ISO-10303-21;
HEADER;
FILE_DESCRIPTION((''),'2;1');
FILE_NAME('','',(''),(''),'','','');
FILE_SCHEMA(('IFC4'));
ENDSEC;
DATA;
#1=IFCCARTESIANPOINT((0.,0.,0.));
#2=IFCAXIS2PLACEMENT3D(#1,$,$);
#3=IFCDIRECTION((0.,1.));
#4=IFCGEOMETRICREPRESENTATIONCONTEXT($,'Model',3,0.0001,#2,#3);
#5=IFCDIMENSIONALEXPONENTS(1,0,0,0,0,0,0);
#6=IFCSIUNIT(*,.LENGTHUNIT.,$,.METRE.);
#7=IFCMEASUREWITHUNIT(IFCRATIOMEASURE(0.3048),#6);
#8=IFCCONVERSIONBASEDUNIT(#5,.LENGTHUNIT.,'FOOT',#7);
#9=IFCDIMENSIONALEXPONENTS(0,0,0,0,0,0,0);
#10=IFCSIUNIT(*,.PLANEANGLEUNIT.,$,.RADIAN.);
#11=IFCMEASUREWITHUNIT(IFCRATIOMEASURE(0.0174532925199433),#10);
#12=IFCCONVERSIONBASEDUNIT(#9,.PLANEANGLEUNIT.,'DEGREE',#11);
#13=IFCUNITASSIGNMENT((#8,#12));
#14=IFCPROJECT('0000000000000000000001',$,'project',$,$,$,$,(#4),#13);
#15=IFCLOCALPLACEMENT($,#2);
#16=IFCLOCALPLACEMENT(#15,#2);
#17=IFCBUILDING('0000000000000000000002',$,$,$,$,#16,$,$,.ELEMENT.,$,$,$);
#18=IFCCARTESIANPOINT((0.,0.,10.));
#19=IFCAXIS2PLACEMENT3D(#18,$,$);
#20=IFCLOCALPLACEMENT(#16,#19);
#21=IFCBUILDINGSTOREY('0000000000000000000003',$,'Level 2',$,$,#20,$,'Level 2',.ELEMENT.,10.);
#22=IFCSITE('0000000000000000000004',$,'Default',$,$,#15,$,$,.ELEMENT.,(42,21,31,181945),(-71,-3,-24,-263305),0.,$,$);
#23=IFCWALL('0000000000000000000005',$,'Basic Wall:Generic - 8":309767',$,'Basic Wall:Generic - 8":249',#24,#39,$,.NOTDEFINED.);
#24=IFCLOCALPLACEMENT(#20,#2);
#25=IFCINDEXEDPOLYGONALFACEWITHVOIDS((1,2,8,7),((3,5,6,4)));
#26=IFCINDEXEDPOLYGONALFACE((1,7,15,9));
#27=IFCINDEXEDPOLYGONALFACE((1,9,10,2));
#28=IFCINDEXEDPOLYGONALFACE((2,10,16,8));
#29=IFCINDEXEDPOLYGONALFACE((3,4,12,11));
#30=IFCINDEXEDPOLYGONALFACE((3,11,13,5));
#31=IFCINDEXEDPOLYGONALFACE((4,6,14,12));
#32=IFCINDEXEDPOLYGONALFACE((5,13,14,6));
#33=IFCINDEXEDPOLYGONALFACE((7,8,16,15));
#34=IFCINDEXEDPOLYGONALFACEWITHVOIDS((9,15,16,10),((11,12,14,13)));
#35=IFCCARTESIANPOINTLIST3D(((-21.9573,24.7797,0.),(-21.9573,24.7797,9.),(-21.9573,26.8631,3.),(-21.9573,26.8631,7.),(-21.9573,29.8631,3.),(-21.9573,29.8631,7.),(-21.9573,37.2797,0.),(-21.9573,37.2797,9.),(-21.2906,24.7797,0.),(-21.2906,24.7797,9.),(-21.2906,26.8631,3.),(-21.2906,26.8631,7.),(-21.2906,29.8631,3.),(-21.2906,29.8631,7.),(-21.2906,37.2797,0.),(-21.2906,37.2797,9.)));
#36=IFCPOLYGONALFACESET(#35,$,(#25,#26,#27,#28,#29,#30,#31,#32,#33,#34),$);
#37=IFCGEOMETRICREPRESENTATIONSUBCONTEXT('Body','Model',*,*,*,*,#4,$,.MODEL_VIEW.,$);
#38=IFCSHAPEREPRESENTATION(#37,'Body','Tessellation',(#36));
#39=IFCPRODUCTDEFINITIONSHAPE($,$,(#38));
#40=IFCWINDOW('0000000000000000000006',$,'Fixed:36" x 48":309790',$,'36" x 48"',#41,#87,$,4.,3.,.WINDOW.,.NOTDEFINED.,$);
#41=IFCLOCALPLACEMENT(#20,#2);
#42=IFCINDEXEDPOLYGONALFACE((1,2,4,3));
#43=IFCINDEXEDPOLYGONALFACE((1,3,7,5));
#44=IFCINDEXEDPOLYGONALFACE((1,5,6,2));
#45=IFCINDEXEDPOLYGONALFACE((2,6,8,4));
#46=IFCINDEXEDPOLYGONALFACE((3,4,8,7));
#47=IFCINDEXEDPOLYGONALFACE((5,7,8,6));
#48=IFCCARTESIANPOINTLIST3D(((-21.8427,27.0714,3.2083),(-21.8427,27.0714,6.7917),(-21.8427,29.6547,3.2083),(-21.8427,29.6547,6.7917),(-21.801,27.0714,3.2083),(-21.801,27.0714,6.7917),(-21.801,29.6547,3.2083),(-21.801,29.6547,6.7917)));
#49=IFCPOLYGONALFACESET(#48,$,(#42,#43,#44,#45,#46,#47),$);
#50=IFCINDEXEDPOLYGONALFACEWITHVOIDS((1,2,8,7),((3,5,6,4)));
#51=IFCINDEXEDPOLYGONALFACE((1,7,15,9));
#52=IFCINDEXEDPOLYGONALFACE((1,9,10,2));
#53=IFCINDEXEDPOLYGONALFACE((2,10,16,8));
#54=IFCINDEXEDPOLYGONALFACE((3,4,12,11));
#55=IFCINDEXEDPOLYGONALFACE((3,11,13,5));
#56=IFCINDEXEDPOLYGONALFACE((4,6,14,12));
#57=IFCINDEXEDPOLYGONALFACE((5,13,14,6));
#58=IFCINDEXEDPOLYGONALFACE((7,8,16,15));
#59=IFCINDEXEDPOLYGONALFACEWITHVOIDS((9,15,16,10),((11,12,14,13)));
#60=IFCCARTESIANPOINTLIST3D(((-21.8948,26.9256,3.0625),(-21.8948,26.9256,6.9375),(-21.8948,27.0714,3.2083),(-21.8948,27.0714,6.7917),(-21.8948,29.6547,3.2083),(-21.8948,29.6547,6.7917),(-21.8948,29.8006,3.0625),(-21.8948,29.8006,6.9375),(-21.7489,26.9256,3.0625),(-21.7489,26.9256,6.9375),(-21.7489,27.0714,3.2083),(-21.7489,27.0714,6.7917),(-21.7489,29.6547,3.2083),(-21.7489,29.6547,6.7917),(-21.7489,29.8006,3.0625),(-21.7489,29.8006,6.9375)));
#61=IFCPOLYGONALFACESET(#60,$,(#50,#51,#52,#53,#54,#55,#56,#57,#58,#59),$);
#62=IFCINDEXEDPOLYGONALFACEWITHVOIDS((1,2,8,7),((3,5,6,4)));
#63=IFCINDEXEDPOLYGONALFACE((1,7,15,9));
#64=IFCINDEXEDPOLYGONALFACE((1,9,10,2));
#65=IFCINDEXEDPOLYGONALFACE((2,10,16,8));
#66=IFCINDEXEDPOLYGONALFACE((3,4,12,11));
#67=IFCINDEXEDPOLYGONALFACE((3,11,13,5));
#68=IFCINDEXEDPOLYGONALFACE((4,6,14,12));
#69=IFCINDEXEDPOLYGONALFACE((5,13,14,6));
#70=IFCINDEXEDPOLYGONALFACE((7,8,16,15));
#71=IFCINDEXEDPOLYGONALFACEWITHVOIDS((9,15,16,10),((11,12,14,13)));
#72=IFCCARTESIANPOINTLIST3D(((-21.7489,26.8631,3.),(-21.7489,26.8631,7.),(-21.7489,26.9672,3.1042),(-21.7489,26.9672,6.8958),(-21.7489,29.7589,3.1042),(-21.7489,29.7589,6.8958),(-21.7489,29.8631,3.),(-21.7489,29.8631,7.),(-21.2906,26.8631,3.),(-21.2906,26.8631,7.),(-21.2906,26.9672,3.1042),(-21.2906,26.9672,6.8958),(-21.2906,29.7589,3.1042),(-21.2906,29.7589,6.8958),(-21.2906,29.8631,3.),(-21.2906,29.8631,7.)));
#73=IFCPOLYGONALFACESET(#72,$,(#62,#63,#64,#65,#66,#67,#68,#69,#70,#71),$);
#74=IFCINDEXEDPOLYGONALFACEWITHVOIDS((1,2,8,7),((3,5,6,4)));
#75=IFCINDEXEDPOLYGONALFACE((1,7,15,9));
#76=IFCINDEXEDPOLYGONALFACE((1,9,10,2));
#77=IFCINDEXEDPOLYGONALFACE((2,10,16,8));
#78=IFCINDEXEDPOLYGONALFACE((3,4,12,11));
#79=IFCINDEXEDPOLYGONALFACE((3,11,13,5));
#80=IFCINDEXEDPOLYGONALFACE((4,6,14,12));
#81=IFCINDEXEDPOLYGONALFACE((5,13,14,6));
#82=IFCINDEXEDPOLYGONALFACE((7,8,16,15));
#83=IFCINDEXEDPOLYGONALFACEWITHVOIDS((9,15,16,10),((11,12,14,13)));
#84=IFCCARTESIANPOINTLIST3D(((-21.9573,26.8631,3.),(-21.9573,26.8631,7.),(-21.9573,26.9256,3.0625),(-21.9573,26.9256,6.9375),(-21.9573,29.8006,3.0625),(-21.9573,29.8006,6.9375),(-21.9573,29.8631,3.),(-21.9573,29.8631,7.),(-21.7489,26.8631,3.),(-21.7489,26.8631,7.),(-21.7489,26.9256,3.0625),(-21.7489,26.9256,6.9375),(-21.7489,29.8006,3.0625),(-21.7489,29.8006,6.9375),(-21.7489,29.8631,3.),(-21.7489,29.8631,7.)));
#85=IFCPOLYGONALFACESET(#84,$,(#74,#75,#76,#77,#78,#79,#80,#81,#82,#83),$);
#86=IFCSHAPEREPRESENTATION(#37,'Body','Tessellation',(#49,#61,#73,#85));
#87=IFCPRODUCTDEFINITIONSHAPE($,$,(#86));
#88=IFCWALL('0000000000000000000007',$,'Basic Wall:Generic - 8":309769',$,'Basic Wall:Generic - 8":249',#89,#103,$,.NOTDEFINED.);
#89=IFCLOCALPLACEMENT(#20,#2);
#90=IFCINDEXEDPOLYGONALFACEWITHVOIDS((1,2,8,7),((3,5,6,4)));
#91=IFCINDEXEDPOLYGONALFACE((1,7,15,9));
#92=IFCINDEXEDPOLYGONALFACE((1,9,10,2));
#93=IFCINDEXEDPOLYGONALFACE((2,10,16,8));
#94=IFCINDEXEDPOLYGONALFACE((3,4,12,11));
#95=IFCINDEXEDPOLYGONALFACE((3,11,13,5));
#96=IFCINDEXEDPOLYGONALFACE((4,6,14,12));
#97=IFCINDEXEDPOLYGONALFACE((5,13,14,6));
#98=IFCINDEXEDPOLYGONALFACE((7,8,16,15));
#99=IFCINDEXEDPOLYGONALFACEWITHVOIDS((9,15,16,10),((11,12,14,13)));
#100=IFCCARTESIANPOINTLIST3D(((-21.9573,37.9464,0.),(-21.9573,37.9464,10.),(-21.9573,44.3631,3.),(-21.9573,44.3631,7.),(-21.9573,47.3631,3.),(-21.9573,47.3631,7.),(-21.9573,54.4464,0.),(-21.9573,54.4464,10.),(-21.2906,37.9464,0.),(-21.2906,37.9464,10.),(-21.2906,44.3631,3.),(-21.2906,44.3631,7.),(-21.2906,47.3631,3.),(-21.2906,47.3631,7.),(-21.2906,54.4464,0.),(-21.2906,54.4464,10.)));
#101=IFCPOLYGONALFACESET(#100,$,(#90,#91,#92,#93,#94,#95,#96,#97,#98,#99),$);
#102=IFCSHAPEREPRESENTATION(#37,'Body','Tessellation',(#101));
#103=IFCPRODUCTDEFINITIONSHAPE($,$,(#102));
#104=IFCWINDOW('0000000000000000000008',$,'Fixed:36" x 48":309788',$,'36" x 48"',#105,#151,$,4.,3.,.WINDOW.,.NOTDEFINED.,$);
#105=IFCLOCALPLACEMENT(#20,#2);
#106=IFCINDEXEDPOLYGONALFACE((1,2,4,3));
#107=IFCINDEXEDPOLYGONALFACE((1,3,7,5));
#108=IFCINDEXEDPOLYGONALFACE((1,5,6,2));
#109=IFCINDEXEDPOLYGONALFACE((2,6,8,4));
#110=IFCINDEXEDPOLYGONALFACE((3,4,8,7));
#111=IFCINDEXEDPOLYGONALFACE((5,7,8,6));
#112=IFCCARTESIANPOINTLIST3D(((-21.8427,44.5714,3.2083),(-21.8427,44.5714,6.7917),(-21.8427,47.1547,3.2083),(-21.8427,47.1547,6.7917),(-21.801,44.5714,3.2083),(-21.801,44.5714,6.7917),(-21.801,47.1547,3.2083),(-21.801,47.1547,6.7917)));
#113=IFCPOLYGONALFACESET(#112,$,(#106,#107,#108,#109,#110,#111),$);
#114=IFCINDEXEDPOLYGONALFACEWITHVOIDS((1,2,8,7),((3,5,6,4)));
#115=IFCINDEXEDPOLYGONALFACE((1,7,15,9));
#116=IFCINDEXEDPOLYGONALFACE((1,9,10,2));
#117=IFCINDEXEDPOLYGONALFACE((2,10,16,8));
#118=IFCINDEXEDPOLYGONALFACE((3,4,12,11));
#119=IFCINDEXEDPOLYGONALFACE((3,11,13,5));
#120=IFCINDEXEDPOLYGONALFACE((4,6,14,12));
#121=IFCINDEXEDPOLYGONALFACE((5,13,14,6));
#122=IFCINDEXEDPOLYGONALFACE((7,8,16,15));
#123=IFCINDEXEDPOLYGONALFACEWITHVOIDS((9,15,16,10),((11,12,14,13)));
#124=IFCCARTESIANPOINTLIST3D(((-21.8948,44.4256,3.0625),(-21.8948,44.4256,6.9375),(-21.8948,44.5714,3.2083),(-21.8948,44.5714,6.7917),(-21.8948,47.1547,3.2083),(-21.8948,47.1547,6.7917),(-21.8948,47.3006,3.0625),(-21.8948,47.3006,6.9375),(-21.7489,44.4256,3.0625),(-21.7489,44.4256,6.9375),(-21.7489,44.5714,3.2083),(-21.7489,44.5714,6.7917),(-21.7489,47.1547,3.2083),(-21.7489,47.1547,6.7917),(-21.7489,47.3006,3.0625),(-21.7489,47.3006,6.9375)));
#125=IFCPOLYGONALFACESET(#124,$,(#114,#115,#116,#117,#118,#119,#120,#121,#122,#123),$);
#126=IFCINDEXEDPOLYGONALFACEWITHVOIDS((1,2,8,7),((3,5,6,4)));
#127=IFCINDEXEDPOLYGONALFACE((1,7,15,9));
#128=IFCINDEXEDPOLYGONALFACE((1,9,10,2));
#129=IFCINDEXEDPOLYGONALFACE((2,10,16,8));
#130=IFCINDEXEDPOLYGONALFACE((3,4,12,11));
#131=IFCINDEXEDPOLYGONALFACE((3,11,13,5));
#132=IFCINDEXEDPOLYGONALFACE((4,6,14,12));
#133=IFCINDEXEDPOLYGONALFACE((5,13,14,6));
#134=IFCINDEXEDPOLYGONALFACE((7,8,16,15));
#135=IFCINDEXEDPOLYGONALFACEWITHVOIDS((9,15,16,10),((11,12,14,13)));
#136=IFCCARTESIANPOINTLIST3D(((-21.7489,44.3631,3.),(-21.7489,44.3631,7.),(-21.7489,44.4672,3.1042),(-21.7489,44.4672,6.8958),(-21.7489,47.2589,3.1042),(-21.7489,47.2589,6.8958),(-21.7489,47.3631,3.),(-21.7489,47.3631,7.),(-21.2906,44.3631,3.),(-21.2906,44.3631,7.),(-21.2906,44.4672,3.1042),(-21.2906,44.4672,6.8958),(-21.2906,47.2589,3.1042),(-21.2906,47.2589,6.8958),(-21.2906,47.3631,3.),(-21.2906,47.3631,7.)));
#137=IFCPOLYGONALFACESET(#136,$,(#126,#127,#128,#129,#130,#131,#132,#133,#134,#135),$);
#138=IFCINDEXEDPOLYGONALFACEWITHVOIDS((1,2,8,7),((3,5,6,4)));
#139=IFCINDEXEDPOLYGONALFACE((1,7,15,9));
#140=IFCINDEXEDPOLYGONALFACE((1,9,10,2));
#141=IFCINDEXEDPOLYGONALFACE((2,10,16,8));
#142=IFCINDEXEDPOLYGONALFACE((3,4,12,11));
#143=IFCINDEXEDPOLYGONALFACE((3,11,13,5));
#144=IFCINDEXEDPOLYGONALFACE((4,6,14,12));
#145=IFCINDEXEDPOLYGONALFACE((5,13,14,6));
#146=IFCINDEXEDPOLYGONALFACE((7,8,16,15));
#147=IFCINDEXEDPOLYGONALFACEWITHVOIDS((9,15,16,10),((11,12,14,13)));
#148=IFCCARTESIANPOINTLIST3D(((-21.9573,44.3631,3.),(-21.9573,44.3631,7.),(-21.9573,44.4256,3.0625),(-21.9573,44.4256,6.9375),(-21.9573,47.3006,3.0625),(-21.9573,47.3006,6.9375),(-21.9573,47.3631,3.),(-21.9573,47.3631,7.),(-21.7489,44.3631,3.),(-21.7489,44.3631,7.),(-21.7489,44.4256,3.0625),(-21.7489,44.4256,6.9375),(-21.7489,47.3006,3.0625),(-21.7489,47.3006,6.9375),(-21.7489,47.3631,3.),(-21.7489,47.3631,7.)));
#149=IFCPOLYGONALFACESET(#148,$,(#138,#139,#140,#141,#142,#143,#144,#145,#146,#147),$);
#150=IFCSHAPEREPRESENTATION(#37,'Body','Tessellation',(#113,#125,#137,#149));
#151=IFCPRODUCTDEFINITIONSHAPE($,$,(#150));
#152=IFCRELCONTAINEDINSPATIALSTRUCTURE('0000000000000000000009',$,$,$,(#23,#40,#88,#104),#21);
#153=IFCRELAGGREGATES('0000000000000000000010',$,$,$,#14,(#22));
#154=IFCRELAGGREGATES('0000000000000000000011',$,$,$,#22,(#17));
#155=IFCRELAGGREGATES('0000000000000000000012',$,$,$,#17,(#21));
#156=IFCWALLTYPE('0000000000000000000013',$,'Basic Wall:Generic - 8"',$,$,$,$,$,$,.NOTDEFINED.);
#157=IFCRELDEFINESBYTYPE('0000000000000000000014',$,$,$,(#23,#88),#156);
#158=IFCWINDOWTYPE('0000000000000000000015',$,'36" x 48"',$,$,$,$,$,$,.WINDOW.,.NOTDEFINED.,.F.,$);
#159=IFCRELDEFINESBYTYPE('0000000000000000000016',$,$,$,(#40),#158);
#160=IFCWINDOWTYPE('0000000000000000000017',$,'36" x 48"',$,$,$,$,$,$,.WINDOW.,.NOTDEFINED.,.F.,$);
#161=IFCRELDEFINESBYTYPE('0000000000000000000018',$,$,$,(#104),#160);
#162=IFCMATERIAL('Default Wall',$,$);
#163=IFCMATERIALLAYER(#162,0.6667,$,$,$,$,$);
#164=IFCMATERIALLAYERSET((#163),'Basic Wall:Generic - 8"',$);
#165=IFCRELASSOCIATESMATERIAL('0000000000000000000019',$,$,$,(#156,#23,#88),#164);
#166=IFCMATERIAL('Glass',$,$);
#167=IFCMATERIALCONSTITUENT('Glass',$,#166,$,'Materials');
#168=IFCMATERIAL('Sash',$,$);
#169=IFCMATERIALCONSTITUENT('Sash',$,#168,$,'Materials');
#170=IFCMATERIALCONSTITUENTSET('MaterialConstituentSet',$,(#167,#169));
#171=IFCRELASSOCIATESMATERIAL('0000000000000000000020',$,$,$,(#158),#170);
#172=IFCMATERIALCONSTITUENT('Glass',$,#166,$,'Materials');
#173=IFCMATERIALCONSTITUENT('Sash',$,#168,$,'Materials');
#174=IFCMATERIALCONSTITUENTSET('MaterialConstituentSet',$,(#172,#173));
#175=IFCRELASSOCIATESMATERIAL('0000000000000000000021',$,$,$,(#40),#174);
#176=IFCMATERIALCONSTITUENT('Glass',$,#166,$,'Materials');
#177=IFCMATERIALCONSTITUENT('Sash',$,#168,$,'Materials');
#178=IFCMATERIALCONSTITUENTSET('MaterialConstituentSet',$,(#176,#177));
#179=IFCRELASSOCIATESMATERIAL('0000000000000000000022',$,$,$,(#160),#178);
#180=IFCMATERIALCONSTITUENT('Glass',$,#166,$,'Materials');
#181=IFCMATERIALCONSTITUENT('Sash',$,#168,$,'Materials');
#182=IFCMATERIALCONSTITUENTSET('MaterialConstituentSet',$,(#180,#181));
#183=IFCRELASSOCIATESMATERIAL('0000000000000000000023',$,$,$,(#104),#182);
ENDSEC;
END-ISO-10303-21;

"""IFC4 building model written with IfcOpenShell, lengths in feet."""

from ifc_helpers import new_model, entity, si_unit, converted_unit, direction, frame, frame_2d, origin, place, context, subcontext, project, spatial, polyline, rectangle, outline, extrude, clip, bounded_halfspace, source, transform, mapped, material, layer, layer_set, layer_usage, constituent, constituent_set, type_object, type_shapes, element, fill, save


model = new_model("IFC4")

# Units and contexts
model_context = context("Model", 3, precision=0.0001, world=origin(), true_north=direction((0.0, 1.0)))
body_context = subcontext(model_context, "Body", "Model", "MODEL_VIEW")
ifc_project = project(units=[converted_unit("LENGTHUNIT", "FOOT", entity("IfcRatioMeasure", 0.3048), si_unit("LENGTHUNIT", "METRE"), dimensions=[1, 0, 0, 0, 0, 0, 0]), converted_unit("PLANEANGLEUNIT", "DEGREE", entity("IfcRatioMeasure", 0.0174532925199433), si_unit("PLANEANGLEUNIT", "RADIAN"), dimensions=[0, 0, 0, 0, 0, 0, 0])], contexts=[model_context])

# Site, building, storey
site_placement = place(None, origin())
site = spatial("IfcSite", under=ifc_project, at=site_placement, Name="Default", CompositionType="ELEMENT", RefLatitude=(42, 21, 31, 181945), RefLongitude=(-71, -3, -24, -263305), RefElevation=0.0)
building_placement = place(site_placement, origin())
building = spatial("IfcBuilding", under=site, at=building_placement, CompositionType="ELEMENT")
storey_placement = place(building_placement, frame((0.0, 0.0, 10.0)))
storey = spatial("IfcBuildingStorey", under=building, at=storey_placement, Name="Level 2", LongName="Level 2", CompositionType="ELEMENT", Elevation=10.0)

# Shared definitions
ifc_material_1 = material(Name="Default Wall")
ifc_layer_1 = layer(ifc_material_1, 0.6667)
ifc_layer_set_1 = layer_set([ifc_layer_1], Name="Basic Wall:Generic - 8\"")
wall_type = type_object("IfcWallType", Name="Basic Wall:Generic - 8\"", PredefinedType="NOTDEFINED", material=ifc_layer_set_1)

# Walls, openings, windows
ifc_layer_usage_1 = layer_usage(ifc_layer_set_1, "AXIS2", "NEGATIVE", 0.3333)
wall_1_placement = place(storey_placement, frame((-21.6239, 24.7797, 0.0), z_axis=(0.0, 0.0, 1.0), x_axis=(0.0, 1.0, 0.0)))
wall_1 = element("IfcWall", 1, at=wall_1_placement, inside=storey, type_object=wall_type, material=ifc_layer_usage_1, Name="Basic Wall:Generic - 8\":309767", ObjectType="Basic Wall:Generic - 8\":249", PredefinedType="NOTDEFINED", context=body_context, shape_type="Clipping", body=[
    clip(extrude(rectangle(XDim=12.5, YDim=0.6667, at=frame_2d((6.25, 0.0), x_axis=(-1.0, 0.0))), origin(), (0.0, 0.0, 1.0), 9.0), bounded_halfspace(frame((0.0, -0.3333, 9.0), z_axis=(0.0, 0.0, -1.0), x_axis=(0.0, -1.0, 0.0)), True, frame((0.0, -0.3333, 9.0)), polyline([(0.0, 0.0), (12.5, 0.0), (12.5, 0.6667), (0.6667, 0.6667), (0.0, 0.6667), (0.0, 0.0)]))),
])
opening_1_placement = place(wall_1_placement, frame((2.0833, -0.3333, 3.0)))
opening_1 = element("IfcOpeningElement", 2, at=opening_1_placement, cuts=wall_1, ObjectType="Opening", PredefinedType="OPENING", context=body_context, shape_type="SweptSolid", body=[
    extrude(rectangle(XDim=4.0, YDim=3.0, at=frame_2d((2.0, 1.5), x_axis=(-1.0, 0.0))), frame((0.0, 0.0, 0.0), z_axis=(0.0, 1.0, 0.0), x_axis=(0.0, 0.0, 1.0)), (0.0, 0.0, 1.0), 0.6667),
])
ifc_material_2 = material(Name="Glass")
ifc_constituent_1 = constituent(ifc_material_2, Name="Glass", Category="Materials")
ifc_material_3 = material(Name="Sash")
ifc_constituent_2 = constituent(ifc_material_3, Name="Sash", Category="Materials")
ifc_constituent_set_1 = constituent_set(constituents=[ifc_constituent_1, ifc_constituent_2], Name="MaterialConstituentSet")
ifc_constituent_3 = constituent(ifc_material_2, Name="Glass", Category="Materials")
ifc_constituent_4 = constituent(ifc_material_3, Name="Sash", Category="Materials")
ifc_constituent_set_2 = constituent_set(constituents=[ifc_constituent_3, ifc_constituent_4], Name="MaterialConstituentSet")
window_type_1 = type_object("IfcWindowType", Name="36\" x 48\"", ParameterTakesPrecedence=False, PartitioningType="NOTDEFINED", PredefinedType="WINDOW", material=ifc_constituent_set_2)
shared_shape_1 = source(origin(), body_context, "Body", "SweptSolid", [
    extrude(rectangle(XDim=2.5833, YDim=0.0417, at=frame_2d((0.0, 0.0), x_axis=(1.0, 0.0))), frame((1.75, 0.5312, 0.2083)), (0.0, 0.0, 1.0), 3.5833),
    extrude(outline(polyline([(-1.4375, -1.9375), (1.4375, -1.9375), (1.4375, 1.9375), (-1.4375, 1.9375), (-1.4375, -1.9375)]), holes=[polyline([(-1.2917, -1.7917), (-1.2917, 1.7917), (1.2917, 1.7917), (1.2917, -1.7917), (-1.2917, -1.7917)])]), frame((1.75, 0.6042, 2.0), z_axis=(0.0, -1.0, 0.0), x_axis=(-1.0, 0.0, 0.0)), (0.0, 0.0, 1.0), 0.1458),
    extrude(outline(polyline([(-1.5, -2.0), (1.5, -2.0), (1.5, 2.0), (-1.5, 2.0), (-1.5, -2.0)]), holes=[polyline([(-1.3958, -1.8958), (-1.3958, 1.8958), (1.3958, 1.8958), (1.3958, -1.8958), (-1.3958, -1.8958)])]), frame((1.75, 0.4583, 2.0), z_axis=(0.0, -1.0, 0.0), x_axis=(-1.0, 0.0, 0.0)), (0.0, 0.0, 1.0), 0.4583),
    extrude(outline(polyline([(-2.0, -1.5), (2.0, -1.5), (2.0, 1.5), (-2.0, 1.5), (-2.0, -1.5)]), holes=[polyline([(-1.9375, -1.4375), (-1.9375, 1.4375), (1.9375, 1.4375), (1.9375, -1.4375), (-1.9375, -1.4375)])]), frame((1.75, 0.6667, 2.0), z_axis=(0.0, -1.0, 0.0), x_axis=(0.0, 0.0, -1.0)), (0.0, 0.0, 1.0), 0.2083),
])
type_shapes(window_type_1, [shared_shape_1])
window_1_placement = place(opening_1_placement, frame((-0.25, 0.0, 0.0)))
window_1 = element("IfcWindow", 3, at=window_1_placement, inside=storey, type_object=window_type_1, material=ifc_constituent_set_1, Name="Fixed:36\" x 48\":309790", ObjectType="36\" x 48\"", OverallHeight=4.0, OverallWidth=3.0, PartitioningType="NOTDEFINED", PredefinedType="WINDOW", context=body_context, shape_type="MappedRepresentation", body=[
    mapped(shared_shape_1, transform((0.0, 0.0, 0.0), scale=1.0)),
])
fill(opening_1, window_1)
ifc_layer_usage_2 = layer_usage(ifc_layer_set_1, "AXIS2", "NEGATIVE", 0.3333)
wall_2_placement = place(storey_placement, frame((-21.6239, 54.4464, 0.0), z_axis=(0.0, 0.0, 1.0), x_axis=(0.0, -1.0, 0.0)))
wall_2 = element("IfcWall", 4, at=wall_2_placement, inside=storey, type_object=wall_type, material=ifc_layer_usage_2, Name="Basic Wall:Generic - 8\":309769", ObjectType="Basic Wall:Generic - 8\":249", PredefinedType="NOTDEFINED", context=body_context, shape_type="SweptSolid", body=[
    extrude(rectangle(XDim=16.5, YDim=0.6667, at=frame_2d((8.25, 0.0), x_axis=(-1.0, 0.0))), origin(), (0.0, 0.0, 1.0), 10.0),
])
opening_2_placement = place(wall_2_placement, frame((10.0833, 0.3333, 3.0)))
opening_2 = element("IfcOpeningElement", 5, at=opening_2_placement, cuts=wall_2, ObjectType="Opening", PredefinedType="OPENING", context=body_context, shape_type="SweptSolid", body=[
    extrude(rectangle(XDim=4.0, YDim=3.0, at=frame_2d((2.0, 1.5), x_axis=(-1.0, 0.0))), frame((0.0, 0.0, 0.0), z_axis=(0.0, -1.0, 0.0), x_axis=(0.0, 0.0, 1.0)), (0.0, 0.0, 1.0), 0.6667),
])
ifc_constituent_5 = constituent(ifc_material_2, Name="Glass", Category="Materials")
ifc_constituent_6 = constituent(ifc_material_3, Name="Sash", Category="Materials")
ifc_constituent_set_3 = constituent_set(constituents=[ifc_constituent_5, ifc_constituent_6], Name="MaterialConstituentSet")
ifc_constituent_7 = constituent(ifc_material_2, Name="Glass", Category="Materials")
ifc_constituent_8 = constituent(ifc_material_3, Name="Sash", Category="Materials")
ifc_constituent_set_4 = constituent_set(constituents=[ifc_constituent_7, ifc_constituent_8], Name="MaterialConstituentSet")
window_type_2 = type_object("IfcWindowType", Name="36\" x 48\"", ParameterTakesPrecedence=False, PartitioningType="NOTDEFINED", PredefinedType="WINDOW", material=ifc_constituent_set_4)
shared_shape_2 = source(origin(), body_context, "Body", "SweptSolid", [
    extrude(rectangle(XDim=0.0417, YDim=2.5833, at=frame_2d((0.0, 0.0), x_axis=(1.0, 0.0))), frame((1.5, 0.5312, 0.2083), z_axis=(0.0, 0.0, 1.0), x_axis=(0.0, 1.0, 0.0)), (0.0, 0.0, 1.0), 3.5833),
    extrude(outline(polyline([(-1.4375, -1.9375), (1.4375, -1.9375), (1.4375, 1.9375), (-1.4375, 1.9375), (-1.4375, -1.9375)]), holes=[polyline([(-1.2917, -1.7917), (-1.2917, 1.7917), (1.2917, 1.7917), (1.2917, -1.7917), (-1.2917, -1.7917)])]), frame((1.5, 0.4583, 2.0), z_axis=(0.0, 1.0, 0.0), x_axis=(1.0, 0.0, 0.0)), (0.0, 0.0, 1.0), 0.1458),
    extrude(outline(polyline([(-1.5, -2.0), (1.5, -2.0), (1.5, 2.0), (-1.5, 2.0), (-1.5, -2.0)]), holes=[polyline([(-1.3958, -1.8958), (-1.3958, 1.8958), (1.3958, 1.8958), (1.3958, -1.8958), (-1.3958, -1.8958)])]), frame((1.5, 0.0, 2.0), z_axis=(0.0, 1.0, 0.0), x_axis=(1.0, 0.0, 0.0)), (0.0, 0.0, 1.0), 0.4583),
    extrude(outline(polyline([(-2.0, -1.5), (2.0, -1.5), (2.0, 1.5), (-2.0, 1.5), (-2.0, -1.5)]), holes=[polyline([(-1.9375, -1.4375), (-1.9375, 1.4375), (1.9375, 1.4375), (1.9375, -1.4375), (-1.9375, -1.4375)])]), frame((1.5, 0.4583, 2.0), z_axis=(0.0, 1.0, 0.0), x_axis=(0.0, 0.0, -1.0)), (0.0, 0.0, 1.0), 0.2083),
])
type_shapes(window_type_2, [shared_shape_2])
window_2_placement = place(opening_2_placement, frame((0.0, 0.0, 0.0), z_axis=(0.0, 0.0, 1.0), x_axis=(-1.0, 0.0, 0.0)))
window_2 = element("IfcWindow", 6, at=window_2_placement, inside=storey, type_object=window_type_2, material=ifc_constituent_set_3, Name="Fixed:36\" x 48\":309788", ObjectType="36\" x 48\"", OverallHeight=4.0, OverallWidth=3.0, PartitioningType="NOTDEFINED", PredefinedType="WINDOW", context=body_context, shape_type="MappedRepresentation", body=[
    mapped(shared_shape_2, transform((0.0, 0.0, 0.0), scale=1.0)),
])
fill(opening_2, window_2)

save(model, "model.ifc")
